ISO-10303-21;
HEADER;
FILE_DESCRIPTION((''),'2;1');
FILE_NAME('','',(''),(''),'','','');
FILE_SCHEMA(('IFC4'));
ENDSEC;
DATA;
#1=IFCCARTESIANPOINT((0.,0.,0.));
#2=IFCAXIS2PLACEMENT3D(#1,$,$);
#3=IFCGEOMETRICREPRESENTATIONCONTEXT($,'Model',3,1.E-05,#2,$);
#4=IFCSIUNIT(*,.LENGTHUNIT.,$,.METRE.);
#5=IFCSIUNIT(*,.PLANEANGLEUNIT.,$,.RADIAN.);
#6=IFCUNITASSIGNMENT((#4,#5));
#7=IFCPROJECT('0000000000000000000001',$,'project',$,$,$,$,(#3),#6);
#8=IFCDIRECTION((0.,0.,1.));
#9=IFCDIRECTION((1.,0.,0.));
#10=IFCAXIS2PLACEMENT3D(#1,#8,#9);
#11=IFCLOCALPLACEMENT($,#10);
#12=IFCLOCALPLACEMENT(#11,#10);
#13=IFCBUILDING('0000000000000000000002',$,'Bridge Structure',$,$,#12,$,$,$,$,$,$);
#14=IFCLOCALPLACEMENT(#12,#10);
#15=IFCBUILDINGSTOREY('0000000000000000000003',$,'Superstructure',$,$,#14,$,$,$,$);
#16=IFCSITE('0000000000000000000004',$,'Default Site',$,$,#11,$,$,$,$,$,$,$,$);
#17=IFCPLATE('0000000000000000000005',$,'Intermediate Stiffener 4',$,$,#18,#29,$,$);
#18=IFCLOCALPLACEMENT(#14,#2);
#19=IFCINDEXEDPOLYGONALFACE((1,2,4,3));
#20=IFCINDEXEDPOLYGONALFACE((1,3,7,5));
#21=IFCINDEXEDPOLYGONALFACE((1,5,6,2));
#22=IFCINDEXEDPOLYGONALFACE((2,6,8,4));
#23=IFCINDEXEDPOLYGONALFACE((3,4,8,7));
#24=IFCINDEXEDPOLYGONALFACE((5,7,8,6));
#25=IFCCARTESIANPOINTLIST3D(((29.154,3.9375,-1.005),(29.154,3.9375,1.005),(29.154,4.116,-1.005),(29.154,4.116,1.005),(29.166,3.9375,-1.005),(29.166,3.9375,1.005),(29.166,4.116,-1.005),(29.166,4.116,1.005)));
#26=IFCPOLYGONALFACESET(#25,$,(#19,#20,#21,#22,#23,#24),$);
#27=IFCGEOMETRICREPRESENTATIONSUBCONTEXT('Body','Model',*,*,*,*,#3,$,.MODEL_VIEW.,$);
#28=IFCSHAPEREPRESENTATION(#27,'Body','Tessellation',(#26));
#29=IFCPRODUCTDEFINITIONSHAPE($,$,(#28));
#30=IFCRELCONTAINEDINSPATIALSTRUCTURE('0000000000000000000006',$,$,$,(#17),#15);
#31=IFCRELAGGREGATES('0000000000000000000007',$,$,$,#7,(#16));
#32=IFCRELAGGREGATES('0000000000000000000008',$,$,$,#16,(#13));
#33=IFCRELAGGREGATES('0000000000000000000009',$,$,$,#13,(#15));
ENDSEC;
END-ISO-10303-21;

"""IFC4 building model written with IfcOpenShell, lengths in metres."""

from ifc_helpers import new_model, si_unit, frame, origin, origin_with_axes, origin_2d_with_axis, place, context, subcontext, project, spatial, rectangle, extrude, element, save


model = new_model("IFC4")

# Units and contexts
model_context = context("Model", 3, precision=1e-05, world=origin())
body_context = subcontext(model_context, "Body", "Model", "MODEL_VIEW")
ifc_project = project(units=[si_unit("LENGTHUNIT", "METRE"), si_unit("PLANEANGLEUNIT", "RADIAN")], contexts=[model_context])

# Site, building, storey
site_placement = place(None, origin_with_axes())
site = spatial("IfcSite", under=ifc_project, at=site_placement, Name="Default Site")
building_placement = place(site_placement, origin_with_axes())
building = spatial("IfcBuilding", under=site, at=building_placement, Name="Bridge Structure")
storey_placement = place(building_placement, origin_with_axes())
storey = spatial("IfcBuildingStorey", under=building, at=storey_placement, Name="Superstructure")

# Plate
for number, where, z_axis, x_axis, name in (
    (1, (29.16, 4.0267, -1.005), (0.0, 0.0, 1.0), (1.0, 0.0, 0.0), "Intermediate Stiffener 4"),
):
    element("IfcPlate", number, at=place(storey_placement, frame(where, z_axis=z_axis, x_axis=x_axis)), inside=storey, Name=name, context=body_context, shape_type="SweptSolid", body=[
        extrude(rectangle(XDim=0.012, YDim=0.1785, at=origin_2d_with_axis()), origin_with_axes(), (0.0, 0.0, 1.0), 2.01),
    ])

save(model, "model.ifc")
